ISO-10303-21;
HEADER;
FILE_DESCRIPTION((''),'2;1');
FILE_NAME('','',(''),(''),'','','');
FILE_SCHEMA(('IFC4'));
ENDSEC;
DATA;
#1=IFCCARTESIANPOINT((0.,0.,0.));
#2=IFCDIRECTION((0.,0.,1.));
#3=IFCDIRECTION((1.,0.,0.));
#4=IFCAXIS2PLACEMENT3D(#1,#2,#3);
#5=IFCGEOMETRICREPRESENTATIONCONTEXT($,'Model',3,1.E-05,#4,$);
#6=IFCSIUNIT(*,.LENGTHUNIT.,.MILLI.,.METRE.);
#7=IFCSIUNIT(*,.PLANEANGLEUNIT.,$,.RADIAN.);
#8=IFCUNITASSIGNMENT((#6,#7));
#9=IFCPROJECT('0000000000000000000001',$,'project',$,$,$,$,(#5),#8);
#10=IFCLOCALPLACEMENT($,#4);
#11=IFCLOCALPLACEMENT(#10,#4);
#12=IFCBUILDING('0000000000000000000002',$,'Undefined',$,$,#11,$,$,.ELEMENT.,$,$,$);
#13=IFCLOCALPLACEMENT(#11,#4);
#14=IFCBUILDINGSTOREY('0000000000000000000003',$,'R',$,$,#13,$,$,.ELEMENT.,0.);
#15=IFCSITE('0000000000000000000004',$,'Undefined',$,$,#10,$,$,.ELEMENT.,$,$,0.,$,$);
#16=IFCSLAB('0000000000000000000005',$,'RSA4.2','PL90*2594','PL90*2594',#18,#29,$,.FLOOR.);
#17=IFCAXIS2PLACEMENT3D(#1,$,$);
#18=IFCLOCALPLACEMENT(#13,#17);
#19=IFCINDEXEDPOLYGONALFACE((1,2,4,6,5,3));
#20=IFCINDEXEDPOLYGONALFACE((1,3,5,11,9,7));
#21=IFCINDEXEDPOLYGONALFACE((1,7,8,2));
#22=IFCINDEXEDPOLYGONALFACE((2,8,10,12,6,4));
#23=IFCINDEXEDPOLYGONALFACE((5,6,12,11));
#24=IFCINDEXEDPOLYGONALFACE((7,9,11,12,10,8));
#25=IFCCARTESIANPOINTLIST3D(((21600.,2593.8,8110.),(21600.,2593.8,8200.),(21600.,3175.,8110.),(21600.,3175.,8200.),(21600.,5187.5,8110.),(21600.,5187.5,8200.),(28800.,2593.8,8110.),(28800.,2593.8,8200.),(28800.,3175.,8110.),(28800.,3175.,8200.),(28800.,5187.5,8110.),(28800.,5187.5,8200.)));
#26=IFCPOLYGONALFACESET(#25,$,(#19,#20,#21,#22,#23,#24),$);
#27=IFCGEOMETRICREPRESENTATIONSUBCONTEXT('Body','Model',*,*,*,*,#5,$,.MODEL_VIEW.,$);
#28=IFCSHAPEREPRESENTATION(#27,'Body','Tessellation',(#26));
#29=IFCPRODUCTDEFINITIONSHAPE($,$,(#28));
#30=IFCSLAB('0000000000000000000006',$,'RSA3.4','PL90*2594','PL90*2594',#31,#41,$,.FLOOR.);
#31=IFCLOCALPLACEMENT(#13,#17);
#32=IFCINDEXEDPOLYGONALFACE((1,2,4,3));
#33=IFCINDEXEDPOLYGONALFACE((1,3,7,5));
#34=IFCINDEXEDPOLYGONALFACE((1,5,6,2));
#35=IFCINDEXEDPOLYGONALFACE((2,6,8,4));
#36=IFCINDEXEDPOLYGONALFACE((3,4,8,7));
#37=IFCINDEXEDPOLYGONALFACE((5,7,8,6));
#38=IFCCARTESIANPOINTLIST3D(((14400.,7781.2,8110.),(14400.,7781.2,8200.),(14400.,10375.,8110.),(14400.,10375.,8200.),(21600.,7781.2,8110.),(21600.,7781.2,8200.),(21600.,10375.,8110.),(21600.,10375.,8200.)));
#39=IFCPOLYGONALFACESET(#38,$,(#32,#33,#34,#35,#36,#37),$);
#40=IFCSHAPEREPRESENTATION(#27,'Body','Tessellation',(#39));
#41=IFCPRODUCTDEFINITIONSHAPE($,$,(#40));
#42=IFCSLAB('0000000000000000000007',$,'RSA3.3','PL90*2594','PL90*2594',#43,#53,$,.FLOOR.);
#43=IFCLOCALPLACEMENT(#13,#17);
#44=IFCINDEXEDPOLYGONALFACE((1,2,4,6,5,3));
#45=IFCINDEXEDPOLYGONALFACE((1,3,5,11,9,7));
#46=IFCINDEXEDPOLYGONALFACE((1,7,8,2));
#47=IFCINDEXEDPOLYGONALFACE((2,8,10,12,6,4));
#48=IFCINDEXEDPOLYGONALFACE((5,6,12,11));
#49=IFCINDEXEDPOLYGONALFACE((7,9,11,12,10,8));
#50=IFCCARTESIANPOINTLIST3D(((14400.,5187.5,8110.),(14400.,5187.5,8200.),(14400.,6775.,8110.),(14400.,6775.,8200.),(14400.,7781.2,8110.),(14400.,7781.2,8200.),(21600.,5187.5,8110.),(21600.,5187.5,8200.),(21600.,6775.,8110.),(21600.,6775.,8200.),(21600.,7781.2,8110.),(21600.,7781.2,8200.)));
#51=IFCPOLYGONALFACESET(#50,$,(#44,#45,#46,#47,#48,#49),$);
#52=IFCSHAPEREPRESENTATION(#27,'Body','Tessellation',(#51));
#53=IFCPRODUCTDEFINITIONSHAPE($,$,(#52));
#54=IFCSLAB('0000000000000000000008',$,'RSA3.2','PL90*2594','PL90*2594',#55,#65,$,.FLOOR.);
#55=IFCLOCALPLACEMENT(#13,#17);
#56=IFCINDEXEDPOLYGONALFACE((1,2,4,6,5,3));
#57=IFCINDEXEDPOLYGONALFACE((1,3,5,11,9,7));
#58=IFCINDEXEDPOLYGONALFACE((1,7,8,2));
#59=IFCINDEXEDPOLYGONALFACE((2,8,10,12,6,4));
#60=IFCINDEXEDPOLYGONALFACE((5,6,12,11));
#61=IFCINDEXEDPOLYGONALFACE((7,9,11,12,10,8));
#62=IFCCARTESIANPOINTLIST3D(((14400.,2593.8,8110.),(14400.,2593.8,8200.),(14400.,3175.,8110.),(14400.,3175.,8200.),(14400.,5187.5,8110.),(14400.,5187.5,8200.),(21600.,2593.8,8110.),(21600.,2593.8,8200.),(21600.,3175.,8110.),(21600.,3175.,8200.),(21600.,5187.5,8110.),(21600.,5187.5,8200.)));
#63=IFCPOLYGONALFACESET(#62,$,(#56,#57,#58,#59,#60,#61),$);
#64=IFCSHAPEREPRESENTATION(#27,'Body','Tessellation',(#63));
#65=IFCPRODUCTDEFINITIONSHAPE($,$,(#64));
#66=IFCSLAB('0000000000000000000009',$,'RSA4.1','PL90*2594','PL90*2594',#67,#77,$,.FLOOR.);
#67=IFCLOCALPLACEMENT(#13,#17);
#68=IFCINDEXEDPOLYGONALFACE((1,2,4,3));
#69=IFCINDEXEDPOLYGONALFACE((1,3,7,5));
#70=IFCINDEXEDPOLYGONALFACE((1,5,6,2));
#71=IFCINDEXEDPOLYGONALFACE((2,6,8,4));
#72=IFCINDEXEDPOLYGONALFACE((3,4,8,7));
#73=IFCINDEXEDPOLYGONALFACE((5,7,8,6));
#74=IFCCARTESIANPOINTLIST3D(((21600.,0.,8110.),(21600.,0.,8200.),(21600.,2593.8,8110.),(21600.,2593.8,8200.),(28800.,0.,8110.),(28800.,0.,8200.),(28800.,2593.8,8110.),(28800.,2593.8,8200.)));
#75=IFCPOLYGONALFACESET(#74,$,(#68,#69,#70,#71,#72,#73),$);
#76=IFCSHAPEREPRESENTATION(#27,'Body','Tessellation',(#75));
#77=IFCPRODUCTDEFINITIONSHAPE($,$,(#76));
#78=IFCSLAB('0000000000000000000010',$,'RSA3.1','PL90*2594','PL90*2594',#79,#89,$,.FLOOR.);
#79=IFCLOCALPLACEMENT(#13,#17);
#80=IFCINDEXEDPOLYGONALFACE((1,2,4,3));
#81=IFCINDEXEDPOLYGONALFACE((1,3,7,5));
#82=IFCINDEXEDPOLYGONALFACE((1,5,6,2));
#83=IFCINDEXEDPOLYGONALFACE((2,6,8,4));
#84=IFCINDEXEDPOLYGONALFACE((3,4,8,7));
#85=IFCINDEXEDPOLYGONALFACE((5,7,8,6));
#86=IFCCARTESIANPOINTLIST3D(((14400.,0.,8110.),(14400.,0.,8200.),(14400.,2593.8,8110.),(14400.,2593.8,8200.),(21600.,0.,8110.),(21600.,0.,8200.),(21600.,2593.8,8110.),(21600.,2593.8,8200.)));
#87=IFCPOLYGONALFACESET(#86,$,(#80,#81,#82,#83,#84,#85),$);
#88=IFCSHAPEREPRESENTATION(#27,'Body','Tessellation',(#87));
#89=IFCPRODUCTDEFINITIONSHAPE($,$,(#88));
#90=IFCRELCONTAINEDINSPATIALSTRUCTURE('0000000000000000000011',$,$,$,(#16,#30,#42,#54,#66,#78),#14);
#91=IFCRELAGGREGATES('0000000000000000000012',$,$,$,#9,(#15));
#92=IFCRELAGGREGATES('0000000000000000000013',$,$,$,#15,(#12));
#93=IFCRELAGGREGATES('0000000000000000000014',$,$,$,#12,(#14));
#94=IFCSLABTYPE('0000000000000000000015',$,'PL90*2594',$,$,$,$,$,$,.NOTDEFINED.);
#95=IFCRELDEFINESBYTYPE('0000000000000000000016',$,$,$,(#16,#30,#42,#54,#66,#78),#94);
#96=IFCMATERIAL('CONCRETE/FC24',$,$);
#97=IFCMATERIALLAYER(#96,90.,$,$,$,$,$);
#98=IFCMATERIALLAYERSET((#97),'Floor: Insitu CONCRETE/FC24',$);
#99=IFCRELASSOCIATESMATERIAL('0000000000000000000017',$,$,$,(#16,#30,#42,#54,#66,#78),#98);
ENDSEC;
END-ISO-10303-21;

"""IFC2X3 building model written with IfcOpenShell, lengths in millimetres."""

from ifc_helpers import new_model, si_unit, frame, origin_with_axes, place, context, subcontext, project, spatial, polyline, outline, extrude, material, layer, layer_set, layer_usage, type_object, element, save


model = new_model("IFC2X3")

# Units and contexts
model_context = context("Model", 3, precision=1e-05, world=origin_with_axes())
body_context = subcontext(model_context, "Body", "Model", "MODEL_VIEW")
ifc_project = project(units=[si_unit("LENGTHUNIT", "METRE", prefix="MILLI"), si_unit("PLANEANGLEUNIT", "RADIAN")], contexts=[model_context])

# Site, building, storey
site_placement = place(None, origin_with_axes())
site = spatial("IfcSite", under=ifc_project, at=site_placement, Name="Undefined", CompositionType="ELEMENT", RefElevation=0.0)
building_placement = place(site_placement, origin_with_axes())
building = spatial("IfcBuilding", under=site, at=building_placement, Name="Undefined", CompositionType="ELEMENT")
storey_placement = place(building_placement, origin_with_axes())
storey = spatial("IfcBuildingStorey", under=building, at=storey_placement, Name="R", CompositionType="ELEMENT", Elevation=0.0)

# Slabs
ifc_material_1 = material(Name="CONCRETE/FC24")
ifc_layer = layer(ifc_material_1, 90.0)
ifc_layer_set = layer_set([ifc_layer], Name="Floor: Insitu CONCRETE/FC24")
slab_type_1 = type_object("IfcSlabType", Name="PL90*2594", PredefinedType="NOTDEFINED")
ifc_layer_usage_1 = layer_usage(ifc_layer_set, "AXIS3", "POSITIVE", -45.0)
slab_1_placement = place(storey_placement, frame((21600.0, 2593.8, 8155.0), z_axis=(0.0, 0.0, 1.0), x_axis=(1.0, 0.0, 0.0)))
element("IfcSlab", 1, at=slab_1_placement, inside=storey, type_object=slab_type_1, material=ifc_layer_usage_1, Name="RSA4.2", Description="PL90*2594", ObjectType="PL90*2594", PredefinedType="FLOOR", context=body_context, shape_type="SweptSolid", body=[
    extrude(outline(polyline([(0.0, 0.0), (7200.0, 0.0), (7200.0, 581.2), (7200.0, 2593.8), (0.0, 2593.8), (0.0, 581.2), (0.0, 0.0)])), frame((0.0, 0.0, -45.0), z_axis=(0.0, 0.0, 1.0), x_axis=(1.0, 0.0, 0.0)), (0.0, 0.0, 1.0), 90.0),
])
ifc_layer_usage_2 = layer_usage(ifc_layer_set, "AXIS3", "POSITIVE", -45.0)
slab_2_placement = place(storey_placement, frame((14400.0, 7781.2, 8155.0), z_axis=(0.0, 0.0, 1.0), x_axis=(1.0, 0.0, 0.0)))
element("IfcSlab", 2, at=slab_2_placement, inside=storey, type_object=slab_type_1, material=ifc_layer_usage_2, Name="RSA3.4", Description="PL90*2594", ObjectType="PL90*2594", PredefinedType="FLOOR", context=body_context, shape_type="SweptSolid", body=[
    extrude(outline(polyline([(0.0, 0.0), (7200.0, 0.0), (7200.0, 2593.8), (0.0, 2593.8), (0.0, 0.0)])), frame((0.0, 0.0, -45.0), z_axis=(0.0, 0.0, 1.0), x_axis=(1.0, 0.0, 0.0)), (0.0, 0.0, 1.0), 90.0),
])
ifc_layer_usage_3 = layer_usage(ifc_layer_set, "AXIS3", "POSITIVE", -45.0)
slab_3_placement = place(storey_placement, frame((14400.0, 5187.5, 8155.0), z_axis=(0.0, 0.0, 1.0), x_axis=(1.0, 0.0, 0.0)))
element("IfcSlab", 3, at=slab_3_placement, inside=storey, type_object=slab_type_1, material=ifc_layer_usage_3, Name="RSA3.3", Description="PL90*2594", ObjectType="PL90*2594", PredefinedType="FLOOR", context=body_context, shape_type="SweptSolid", body=[
    extrude(outline(polyline([(0.0, 0.0), (7200.0, 0.0), (7200.0, 1587.5), (7200.0, 2593.8), (0.0, 2593.8), (0.0, 1587.5), (0.0, 0.0)])), frame((0.0, 0.0, -45.0), z_axis=(0.0, 0.0, 1.0), x_axis=(1.0, 0.0, 0.0)), (0.0, 0.0, 1.0), 90.0),
])
ifc_layer_usage_4 = layer_usage(ifc_layer_set, "AXIS3", "POSITIVE", -45.0)
slab_4_placement = place(storey_placement, frame((14400.0, 2593.8, 8155.0), z_axis=(0.0, 0.0, 1.0), x_axis=(1.0, 0.0, 0.0)))
element("IfcSlab", 4, at=slab_4_placement, inside=storey, type_object=slab_type_1, material=ifc_layer_usage_4, Name="RSA3.2", Description="PL90*2594", ObjectType="PL90*2594", PredefinedType="FLOOR", context=body_context, shape_type="SweptSolid", body=[
    extrude(outline(polyline([(0.0, 0.0), (7200.0, 0.0), (7200.0, 581.2), (7200.0, 2593.8), (0.0, 2593.8), (0.0, 581.2), (0.0, 0.0)])), frame((0.0, 0.0, -45.0), z_axis=(0.0, 0.0, 1.0), x_axis=(1.0, 0.0, 0.0)), (0.0, 0.0, 1.0), 90.0),
])
ifc_layer_usage_5 = layer_usage(ifc_layer_set, "AXIS3", "POSITIVE", -45.0)
slab_5_placement = place(storey_placement, frame((21600.0, 0.0, 8155.0), z_axis=(0.0, 0.0, 1.0), x_axis=(1.0, 0.0, 0.0)))
element("IfcSlab", 5, at=slab_5_placement, inside=storey, type_object=slab_type_1, material=ifc_layer_usage_5, Name="RSA4.1", Description="PL90*2594", ObjectType="PL90*2594", PredefinedType="FLOOR", context=body_context, shape_type="SweptSolid", body=[
    extrude(outline(polyline([(0.0, 0.0), (7200.0, 0.0), (7200.0, 2593.8), (0.0, 2593.8), (0.0, 0.0)])), frame((0.0, 0.0, -45.0), z_axis=(0.0, 0.0, 1.0), x_axis=(1.0, 0.0, 0.0)), (0.0, 0.0, 1.0), 90.0),
])
ifc_layer_usage_6 = layer_usage(ifc_layer_set, "AXIS3", "POSITIVE", -45.0)
slab_6_placement = place(storey_placement, frame((14400.0, 0.0, 8155.0), z_axis=(0.0, 0.0, 1.0), x_axis=(1.0, 0.0, 0.0)))
element("IfcSlab", 6, at=slab_6_placement, inside=storey, type_object=slab_type_1, material=ifc_layer_usage_6, Name="RSA3.1", Description="PL90*2594", ObjectType="PL90*2594", PredefinedType="FLOOR", context=body_context, shape_type="SweptSolid", body=[
    extrude(outline(polyline([(0.0, 0.0), (7200.0, 0.0), (7200.0, 2593.8), (0.0, 2593.8), (0.0, 0.0)])), frame((0.0, 0.0, -45.0), z_axis=(0.0, 0.0, 1.0), x_axis=(1.0, 0.0, 0.0)), (0.0, 0.0, 1.0), 90.0),
])

save(model, "model.ifc")
